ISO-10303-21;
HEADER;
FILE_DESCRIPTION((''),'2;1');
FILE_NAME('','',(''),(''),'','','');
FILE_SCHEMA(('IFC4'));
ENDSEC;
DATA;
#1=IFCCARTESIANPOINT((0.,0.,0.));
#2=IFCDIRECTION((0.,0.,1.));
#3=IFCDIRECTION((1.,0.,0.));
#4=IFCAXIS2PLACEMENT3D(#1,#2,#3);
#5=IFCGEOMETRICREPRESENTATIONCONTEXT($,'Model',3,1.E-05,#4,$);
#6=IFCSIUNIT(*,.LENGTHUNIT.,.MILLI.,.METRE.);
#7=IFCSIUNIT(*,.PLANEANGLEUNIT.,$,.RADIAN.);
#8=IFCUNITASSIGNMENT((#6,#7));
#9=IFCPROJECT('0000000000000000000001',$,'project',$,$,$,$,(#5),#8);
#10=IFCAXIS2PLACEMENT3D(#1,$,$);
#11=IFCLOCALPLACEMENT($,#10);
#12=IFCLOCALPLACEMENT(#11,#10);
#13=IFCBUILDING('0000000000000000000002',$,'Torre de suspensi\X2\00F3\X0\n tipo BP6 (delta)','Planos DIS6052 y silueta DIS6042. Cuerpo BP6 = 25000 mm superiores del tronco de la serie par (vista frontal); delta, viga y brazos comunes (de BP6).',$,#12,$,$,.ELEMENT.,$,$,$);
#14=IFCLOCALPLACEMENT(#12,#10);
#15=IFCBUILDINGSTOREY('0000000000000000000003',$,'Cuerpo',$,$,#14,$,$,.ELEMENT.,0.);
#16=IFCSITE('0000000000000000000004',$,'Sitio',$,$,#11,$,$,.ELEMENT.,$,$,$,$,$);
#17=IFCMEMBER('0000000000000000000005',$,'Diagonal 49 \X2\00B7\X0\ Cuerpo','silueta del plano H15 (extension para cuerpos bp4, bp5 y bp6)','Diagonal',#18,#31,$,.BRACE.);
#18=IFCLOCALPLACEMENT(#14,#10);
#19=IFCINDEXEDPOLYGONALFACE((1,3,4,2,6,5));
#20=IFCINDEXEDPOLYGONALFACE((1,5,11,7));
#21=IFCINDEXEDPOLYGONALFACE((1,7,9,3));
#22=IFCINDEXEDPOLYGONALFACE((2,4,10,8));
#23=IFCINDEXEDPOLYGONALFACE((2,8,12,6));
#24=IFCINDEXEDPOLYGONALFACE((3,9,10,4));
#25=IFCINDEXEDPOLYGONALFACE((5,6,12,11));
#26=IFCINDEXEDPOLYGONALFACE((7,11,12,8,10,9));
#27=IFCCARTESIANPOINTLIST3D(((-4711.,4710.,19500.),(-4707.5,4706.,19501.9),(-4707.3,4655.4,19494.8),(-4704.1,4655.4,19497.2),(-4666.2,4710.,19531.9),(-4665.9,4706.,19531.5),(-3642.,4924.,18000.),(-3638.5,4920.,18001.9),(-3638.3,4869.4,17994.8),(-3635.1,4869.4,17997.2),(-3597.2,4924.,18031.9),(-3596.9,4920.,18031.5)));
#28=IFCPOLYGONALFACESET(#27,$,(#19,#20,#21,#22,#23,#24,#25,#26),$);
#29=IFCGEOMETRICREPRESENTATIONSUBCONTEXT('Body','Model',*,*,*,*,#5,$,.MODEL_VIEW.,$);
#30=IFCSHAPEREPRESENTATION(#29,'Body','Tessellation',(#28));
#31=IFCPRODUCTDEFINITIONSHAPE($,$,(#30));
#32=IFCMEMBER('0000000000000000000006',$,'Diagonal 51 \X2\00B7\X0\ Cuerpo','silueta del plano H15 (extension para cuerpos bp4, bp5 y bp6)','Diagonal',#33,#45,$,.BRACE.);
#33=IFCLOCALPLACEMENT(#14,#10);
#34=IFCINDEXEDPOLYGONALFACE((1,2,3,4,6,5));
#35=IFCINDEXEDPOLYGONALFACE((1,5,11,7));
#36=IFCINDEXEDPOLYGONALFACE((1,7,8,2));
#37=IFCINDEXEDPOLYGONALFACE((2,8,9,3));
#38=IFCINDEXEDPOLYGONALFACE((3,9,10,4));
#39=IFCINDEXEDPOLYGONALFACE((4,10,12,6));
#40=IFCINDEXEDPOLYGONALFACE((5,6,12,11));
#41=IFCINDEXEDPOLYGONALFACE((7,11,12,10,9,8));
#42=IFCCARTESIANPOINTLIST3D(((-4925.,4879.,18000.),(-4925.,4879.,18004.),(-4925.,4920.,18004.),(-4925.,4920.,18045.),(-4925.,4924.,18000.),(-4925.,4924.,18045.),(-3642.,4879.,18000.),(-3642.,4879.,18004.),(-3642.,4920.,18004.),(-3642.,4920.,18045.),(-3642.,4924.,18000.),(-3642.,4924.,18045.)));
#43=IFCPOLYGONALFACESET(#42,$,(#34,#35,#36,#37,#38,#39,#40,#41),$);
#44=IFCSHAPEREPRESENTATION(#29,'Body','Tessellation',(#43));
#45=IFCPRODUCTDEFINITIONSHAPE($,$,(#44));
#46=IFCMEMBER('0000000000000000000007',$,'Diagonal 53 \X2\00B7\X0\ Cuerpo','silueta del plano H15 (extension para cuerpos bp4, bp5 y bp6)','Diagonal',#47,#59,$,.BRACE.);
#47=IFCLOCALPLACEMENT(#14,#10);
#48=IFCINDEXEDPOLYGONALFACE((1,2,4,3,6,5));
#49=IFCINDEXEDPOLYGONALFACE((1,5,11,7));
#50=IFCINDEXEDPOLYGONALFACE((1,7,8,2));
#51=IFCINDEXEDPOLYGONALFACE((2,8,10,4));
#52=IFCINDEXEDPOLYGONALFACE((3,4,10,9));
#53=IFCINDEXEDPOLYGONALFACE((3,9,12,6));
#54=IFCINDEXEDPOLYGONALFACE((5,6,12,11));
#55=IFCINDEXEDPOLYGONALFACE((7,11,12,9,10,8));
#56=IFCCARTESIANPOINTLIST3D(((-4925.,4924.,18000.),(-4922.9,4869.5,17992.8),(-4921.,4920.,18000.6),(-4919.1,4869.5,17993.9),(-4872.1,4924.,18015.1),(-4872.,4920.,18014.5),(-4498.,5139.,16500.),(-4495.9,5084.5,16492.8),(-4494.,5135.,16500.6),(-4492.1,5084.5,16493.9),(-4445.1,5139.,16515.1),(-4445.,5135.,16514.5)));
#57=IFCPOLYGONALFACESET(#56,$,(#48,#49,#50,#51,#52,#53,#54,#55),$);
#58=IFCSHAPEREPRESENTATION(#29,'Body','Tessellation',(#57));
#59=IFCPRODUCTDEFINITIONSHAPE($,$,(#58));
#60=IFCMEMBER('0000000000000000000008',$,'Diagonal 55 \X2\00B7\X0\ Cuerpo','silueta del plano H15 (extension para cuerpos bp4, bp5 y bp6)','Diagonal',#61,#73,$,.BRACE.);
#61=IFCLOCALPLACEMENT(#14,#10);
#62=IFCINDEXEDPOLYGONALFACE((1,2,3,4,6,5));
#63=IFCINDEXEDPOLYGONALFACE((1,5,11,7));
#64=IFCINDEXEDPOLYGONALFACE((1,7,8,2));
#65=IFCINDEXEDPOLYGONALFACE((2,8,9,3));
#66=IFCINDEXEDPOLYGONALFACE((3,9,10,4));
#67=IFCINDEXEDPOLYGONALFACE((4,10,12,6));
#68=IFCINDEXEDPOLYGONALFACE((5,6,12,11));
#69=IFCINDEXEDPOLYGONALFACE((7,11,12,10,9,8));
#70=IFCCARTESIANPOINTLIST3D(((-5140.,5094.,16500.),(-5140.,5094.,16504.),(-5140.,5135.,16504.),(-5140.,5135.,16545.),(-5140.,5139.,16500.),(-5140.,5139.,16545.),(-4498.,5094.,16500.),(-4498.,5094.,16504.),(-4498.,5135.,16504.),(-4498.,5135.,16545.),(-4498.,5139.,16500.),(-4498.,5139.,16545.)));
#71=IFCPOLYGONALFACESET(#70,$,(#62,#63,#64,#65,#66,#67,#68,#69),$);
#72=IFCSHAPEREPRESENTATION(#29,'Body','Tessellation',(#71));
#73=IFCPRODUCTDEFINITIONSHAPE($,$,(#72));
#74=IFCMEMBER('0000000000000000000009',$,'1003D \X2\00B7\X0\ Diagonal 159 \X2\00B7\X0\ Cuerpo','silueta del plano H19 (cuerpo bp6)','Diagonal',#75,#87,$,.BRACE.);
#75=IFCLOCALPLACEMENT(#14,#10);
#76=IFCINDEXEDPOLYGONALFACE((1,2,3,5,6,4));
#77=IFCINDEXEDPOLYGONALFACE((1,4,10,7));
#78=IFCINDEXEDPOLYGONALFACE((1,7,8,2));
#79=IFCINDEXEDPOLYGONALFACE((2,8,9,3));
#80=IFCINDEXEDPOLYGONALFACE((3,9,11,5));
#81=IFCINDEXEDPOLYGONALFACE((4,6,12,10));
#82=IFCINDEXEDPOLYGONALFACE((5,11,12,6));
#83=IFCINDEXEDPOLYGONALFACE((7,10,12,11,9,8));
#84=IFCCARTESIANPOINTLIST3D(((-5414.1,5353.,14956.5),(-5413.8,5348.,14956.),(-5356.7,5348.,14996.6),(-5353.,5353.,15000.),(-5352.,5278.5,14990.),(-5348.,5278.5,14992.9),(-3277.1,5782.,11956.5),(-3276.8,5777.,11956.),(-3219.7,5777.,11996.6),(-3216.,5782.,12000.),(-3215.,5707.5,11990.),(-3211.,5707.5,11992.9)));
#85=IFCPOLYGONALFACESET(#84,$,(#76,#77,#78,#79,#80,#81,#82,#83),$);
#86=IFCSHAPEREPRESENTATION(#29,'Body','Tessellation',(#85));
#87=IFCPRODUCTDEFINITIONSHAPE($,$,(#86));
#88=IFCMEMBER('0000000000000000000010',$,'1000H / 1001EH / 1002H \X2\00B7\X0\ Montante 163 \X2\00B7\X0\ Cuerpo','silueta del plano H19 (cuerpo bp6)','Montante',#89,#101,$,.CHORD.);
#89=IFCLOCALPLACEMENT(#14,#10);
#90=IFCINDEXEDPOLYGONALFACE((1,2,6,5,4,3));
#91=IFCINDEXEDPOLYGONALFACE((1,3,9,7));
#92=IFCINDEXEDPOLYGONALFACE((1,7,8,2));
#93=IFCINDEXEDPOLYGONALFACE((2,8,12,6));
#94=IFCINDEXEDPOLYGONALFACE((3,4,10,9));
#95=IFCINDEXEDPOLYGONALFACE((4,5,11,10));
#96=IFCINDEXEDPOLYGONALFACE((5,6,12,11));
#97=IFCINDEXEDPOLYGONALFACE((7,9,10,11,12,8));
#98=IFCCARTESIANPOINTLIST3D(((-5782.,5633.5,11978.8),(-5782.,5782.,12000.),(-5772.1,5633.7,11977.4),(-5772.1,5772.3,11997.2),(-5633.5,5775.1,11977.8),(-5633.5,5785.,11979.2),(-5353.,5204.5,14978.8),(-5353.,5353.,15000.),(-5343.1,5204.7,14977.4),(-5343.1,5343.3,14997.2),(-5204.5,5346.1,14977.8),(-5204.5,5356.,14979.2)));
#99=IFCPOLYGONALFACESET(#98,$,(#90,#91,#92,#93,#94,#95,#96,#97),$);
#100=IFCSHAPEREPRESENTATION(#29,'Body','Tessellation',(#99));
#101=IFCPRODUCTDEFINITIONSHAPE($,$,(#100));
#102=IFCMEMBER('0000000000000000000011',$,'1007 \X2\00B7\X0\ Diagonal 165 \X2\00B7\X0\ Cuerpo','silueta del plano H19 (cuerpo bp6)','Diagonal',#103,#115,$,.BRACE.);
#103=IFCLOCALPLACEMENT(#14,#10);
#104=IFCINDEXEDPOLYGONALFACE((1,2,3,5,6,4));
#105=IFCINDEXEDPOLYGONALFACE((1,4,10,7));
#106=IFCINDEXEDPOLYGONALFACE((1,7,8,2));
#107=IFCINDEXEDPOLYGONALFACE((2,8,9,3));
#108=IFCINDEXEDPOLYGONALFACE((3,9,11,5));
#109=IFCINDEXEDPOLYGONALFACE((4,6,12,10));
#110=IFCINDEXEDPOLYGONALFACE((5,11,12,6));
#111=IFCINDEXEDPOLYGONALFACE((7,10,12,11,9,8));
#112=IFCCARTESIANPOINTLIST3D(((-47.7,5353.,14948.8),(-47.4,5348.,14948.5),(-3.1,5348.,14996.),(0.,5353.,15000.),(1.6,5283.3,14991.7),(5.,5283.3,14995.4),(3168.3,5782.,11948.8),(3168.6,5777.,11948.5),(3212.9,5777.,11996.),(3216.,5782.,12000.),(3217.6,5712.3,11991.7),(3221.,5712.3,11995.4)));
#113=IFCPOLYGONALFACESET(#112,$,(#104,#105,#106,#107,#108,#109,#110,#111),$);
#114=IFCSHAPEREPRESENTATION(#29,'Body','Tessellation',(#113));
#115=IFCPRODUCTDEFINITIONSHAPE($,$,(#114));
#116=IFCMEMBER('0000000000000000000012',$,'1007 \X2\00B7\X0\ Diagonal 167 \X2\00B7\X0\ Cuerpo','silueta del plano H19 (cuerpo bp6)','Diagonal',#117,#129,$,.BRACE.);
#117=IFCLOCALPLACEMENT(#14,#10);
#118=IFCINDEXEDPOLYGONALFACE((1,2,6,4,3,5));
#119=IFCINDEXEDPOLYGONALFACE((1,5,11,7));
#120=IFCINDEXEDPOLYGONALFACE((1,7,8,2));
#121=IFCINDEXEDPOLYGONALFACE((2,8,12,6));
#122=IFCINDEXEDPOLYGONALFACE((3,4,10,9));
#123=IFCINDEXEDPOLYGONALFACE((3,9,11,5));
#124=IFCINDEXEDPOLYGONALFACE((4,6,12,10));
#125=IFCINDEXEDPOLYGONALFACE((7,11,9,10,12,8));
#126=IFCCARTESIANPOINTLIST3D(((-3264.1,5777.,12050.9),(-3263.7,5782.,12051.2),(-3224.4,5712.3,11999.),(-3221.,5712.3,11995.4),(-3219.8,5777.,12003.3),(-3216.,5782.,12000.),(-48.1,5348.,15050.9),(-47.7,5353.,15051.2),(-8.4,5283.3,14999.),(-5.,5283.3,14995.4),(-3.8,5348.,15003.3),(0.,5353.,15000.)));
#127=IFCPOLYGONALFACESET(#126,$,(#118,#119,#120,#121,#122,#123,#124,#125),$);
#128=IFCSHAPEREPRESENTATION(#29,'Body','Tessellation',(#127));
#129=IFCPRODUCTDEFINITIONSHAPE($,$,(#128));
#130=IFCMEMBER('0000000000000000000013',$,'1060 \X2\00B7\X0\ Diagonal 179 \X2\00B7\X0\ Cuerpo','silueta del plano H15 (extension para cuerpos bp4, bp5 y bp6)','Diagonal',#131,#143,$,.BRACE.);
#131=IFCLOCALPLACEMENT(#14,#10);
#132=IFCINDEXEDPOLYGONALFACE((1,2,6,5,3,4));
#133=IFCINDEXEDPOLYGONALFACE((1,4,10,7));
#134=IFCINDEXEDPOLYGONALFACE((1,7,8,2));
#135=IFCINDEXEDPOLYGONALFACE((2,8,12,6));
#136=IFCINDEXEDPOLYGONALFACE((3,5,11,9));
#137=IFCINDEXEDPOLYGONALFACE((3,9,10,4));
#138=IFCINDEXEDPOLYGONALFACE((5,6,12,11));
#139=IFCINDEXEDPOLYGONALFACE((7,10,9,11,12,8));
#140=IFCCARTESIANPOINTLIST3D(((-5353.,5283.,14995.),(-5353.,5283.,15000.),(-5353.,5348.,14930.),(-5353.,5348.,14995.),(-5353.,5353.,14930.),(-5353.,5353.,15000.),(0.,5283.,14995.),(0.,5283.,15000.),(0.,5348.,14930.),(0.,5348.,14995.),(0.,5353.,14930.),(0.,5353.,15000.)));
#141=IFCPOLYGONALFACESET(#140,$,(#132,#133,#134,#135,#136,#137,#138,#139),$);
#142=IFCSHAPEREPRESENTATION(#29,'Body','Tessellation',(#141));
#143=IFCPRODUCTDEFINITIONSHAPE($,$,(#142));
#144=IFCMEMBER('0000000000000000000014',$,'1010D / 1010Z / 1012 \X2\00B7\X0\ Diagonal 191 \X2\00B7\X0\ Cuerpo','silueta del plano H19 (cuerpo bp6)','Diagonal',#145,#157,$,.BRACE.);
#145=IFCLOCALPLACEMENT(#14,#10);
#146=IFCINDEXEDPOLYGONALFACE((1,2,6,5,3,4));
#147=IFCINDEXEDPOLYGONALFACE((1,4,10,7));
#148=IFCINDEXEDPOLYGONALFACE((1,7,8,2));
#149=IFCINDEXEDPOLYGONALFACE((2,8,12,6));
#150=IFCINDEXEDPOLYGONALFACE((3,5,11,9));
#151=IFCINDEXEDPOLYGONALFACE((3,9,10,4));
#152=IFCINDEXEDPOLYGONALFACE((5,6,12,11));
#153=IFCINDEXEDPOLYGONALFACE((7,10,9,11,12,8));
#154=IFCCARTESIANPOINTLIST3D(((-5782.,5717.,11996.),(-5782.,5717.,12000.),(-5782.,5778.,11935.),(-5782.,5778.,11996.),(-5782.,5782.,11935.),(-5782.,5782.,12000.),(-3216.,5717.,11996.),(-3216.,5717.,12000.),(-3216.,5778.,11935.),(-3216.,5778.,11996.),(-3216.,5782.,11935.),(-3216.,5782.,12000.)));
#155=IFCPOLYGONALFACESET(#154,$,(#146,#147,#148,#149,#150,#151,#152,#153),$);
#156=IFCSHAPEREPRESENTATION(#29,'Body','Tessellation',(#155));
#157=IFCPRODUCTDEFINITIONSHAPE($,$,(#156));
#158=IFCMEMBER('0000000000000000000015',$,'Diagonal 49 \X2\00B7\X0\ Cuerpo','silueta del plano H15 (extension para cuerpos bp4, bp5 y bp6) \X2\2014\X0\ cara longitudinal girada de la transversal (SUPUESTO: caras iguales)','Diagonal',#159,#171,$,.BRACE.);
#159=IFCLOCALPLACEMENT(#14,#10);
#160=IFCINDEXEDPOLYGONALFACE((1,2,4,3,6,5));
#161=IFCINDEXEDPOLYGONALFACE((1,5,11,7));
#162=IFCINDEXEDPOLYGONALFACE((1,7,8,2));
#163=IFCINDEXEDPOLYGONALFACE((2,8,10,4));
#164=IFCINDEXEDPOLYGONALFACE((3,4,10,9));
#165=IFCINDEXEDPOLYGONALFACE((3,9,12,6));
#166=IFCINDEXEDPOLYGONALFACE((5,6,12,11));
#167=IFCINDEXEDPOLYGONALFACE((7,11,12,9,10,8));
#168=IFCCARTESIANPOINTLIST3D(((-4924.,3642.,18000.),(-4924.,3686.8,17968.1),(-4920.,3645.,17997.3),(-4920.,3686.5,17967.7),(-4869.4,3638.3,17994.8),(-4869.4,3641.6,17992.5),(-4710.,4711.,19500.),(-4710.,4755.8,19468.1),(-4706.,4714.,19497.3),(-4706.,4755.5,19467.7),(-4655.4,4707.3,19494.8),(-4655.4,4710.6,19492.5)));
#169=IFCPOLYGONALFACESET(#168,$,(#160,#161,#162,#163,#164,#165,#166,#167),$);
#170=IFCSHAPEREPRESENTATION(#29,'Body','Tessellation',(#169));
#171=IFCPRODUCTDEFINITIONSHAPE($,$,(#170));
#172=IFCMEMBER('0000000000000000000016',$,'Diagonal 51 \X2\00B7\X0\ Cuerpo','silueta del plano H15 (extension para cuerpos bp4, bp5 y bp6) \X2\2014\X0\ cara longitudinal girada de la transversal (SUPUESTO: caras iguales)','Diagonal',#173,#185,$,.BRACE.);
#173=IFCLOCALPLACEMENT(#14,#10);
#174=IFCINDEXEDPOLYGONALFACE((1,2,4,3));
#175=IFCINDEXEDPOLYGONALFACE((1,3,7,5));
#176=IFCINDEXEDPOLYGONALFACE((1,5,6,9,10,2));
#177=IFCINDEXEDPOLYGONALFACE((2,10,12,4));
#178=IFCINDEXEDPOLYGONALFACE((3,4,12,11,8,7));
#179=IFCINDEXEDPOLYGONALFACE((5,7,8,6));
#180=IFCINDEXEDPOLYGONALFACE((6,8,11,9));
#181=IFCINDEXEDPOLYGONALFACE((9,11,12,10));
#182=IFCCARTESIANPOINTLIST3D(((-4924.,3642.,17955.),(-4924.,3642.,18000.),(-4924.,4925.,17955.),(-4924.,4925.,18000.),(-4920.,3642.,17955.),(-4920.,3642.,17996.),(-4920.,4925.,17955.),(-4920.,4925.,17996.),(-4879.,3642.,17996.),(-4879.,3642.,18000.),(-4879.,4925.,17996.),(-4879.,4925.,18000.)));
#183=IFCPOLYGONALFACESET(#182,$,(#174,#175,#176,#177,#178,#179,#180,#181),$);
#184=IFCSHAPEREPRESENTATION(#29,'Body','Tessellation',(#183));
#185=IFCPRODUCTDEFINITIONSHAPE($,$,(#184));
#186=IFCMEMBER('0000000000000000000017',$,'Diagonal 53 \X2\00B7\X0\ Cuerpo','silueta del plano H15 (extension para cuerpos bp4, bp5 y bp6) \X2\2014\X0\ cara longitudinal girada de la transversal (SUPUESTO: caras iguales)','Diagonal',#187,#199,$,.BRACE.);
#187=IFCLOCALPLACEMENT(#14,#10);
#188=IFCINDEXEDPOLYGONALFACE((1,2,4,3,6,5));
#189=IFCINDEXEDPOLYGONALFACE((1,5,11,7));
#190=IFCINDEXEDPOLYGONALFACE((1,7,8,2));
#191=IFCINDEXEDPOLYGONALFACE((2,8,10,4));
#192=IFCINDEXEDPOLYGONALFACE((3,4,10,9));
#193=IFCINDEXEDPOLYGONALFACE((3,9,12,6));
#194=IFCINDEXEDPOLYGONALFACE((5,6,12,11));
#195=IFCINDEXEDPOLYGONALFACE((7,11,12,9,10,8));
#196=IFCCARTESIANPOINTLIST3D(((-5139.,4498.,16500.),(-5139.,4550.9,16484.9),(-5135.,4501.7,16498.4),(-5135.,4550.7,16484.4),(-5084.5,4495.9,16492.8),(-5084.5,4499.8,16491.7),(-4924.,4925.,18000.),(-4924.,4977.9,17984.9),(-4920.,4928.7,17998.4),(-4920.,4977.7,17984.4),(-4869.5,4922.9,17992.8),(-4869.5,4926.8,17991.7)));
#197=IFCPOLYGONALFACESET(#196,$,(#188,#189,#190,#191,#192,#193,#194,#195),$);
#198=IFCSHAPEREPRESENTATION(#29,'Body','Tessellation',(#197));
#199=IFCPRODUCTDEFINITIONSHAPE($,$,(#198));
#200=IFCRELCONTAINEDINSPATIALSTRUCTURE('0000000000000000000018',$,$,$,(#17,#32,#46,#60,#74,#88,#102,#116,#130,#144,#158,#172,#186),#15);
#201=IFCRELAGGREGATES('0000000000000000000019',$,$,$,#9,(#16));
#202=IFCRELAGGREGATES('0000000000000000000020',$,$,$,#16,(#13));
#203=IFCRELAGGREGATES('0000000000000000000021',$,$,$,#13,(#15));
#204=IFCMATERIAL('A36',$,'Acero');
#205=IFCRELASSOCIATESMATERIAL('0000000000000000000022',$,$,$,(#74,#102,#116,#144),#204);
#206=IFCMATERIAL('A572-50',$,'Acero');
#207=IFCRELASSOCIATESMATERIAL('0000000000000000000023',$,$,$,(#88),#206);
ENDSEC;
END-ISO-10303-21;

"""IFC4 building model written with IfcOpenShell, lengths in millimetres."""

from ifc_helpers import new_model, si_unit, frame, frame_2d, origin, origin_with_axes, place, context, subcontext, project, spatial, l_section, extrude, material, element, save


model = new_model("IFC4")

# Units and contexts
model_context = context("Model", 3, precision=1e-05, world=origin_with_axes())
body_context = subcontext(model_context, "Body", "Model", "MODEL_VIEW")
ifc_project = project(units=[si_unit("LENGTHUNIT", "METRE", prefix="MILLI"), si_unit("PLANEANGLEUNIT", "RADIAN")], contexts=[model_context])

# Site, building, storey
site_placement = place(None, origin())
site = spatial("IfcSite", under=ifc_project, at=site_placement, Name="Sitio", CompositionType="ELEMENT")
building_placement = place(site_placement, origin())
building = spatial("IfcBuilding", under=site, at=building_placement, Name="Torre de suspensión tipo BP6 (delta)", Description="Planos DIS6052 y silueta DIS6042. Cuerpo BP6 = 25000 mm superiores del tronco de la serie par (vista frontal); delta, viga y brazos comunes (de BP6).", CompositionType="ELEMENT")
storey_placement = place(building_placement, origin())
storey = spatial("IfcBuildingStorey", under=building, at=storey_placement, Name="Cuerpo", CompositionType="ELEMENT", Elevation=0.0)

# Members
member_1_placement = place(storey_placement, frame((-3642.0, 4924.0, 18000.0), z_axis=(-0.576487, -0.115405, 0.808915), x_axis=(0.066977, -0.993318, -0.093981)))
element("IfcMember", 1, at=member_1_placement, inside=storey, Name="Diagonal 49 · Cuerpo", Description="silueta del plano H15 (extension para cuerpos bp4, bp5 y bp6)", ObjectType="Diagonal", PredefinedType="BRACE", context=body_context, shape_type="SweptSolid", body=[
    extrude(l_section(Depth=55.0, Width=55.0, Thickness=4.0, at=frame_2d((27.5, 27.5))), None, (0.0, 0.0, 1.0), 1854.3),
])
member_2_placement = place(storey_placement, frame((-3642.0, 4924.0, 18000.0), z_axis=(-1.0, 0.0, 0.0), x_axis=(0.0, -1.0, 0.0)))
element("IfcMember", 2, at=member_2_placement, inside=storey, Name="Diagonal 51 · Cuerpo", Description="silueta del plano H15 (extension para cuerpos bp4, bp5 y bp6)", ObjectType="Diagonal", PredefinedType="BRACE", context=body_context, shape_type="SweptSolid", body=[
    extrude(l_section(Depth=45.0, Width=45.0, Thickness=4.0, at=frame_2d((22.5, 22.5))), None, (0.0, 0.0, 1.0), 1283.0),
])
member_3_placement = place(storey_placement, frame((-4498.0, 5139.0, 16500.0), z_axis=(-0.271224, -0.136565, 0.952779), x_axis=(0.03739, -0.990631, -0.131347)))
element("IfcMember", 3, at=member_3_placement, inside=storey, Name="Diagonal 53 · Cuerpo", Description="silueta del plano H15 (extension para cuerpos bp4, bp5 y bp6)", ObjectType="Diagonal", PredefinedType="BRACE", context=body_context, shape_type="SweptSolid", body=[
    extrude(l_section(Depth=55.0, Width=55.0, Thickness=4.0, at=frame_2d((27.5, 27.5))), None, (0.0, 0.0, 1.0), 1574.3),
])
member_4_placement = place(storey_placement, frame((-4498.0, 5139.0, 16500.0), z_axis=(-1.0, 0.0, 0.0), x_axis=(0.0, -1.0, 0.0)))
element("IfcMember", 4, at=member_4_placement, inside=storey, Name="Diagonal 55 · Cuerpo", Description="silueta del plano H15 (extension para cuerpos bp4, bp5 y bp6)", ObjectType="Diagonal", PredefinedType="BRACE", context=body_context, shape_type="SweptSolid", body=[
    extrude(l_section(Depth=45.0, Width=45.0, Thickness=4.0, at=frame_2d((22.5, 22.5))), None, (0.0, 0.0, 1.0), 642.0),
])
ifc_material_1 = material(Name="A36", Category="Acero")
member_5_placement = place(storey_placement, frame((-5353.0, 5353.0, 15000.0), z_axis=(0.576289, 0.115689, -0.809016), x_axis=(0.067121, -0.993285, -0.094227)))
element("IfcMember", 5, at=member_5_placement, inside=storey, material=ifc_material_1, Name="1003D · Diagonal 159 · Cuerpo", Description="silueta del plano H19 (cuerpo bp6)", ObjectType="Diagonal", PredefinedType="BRACE", context=body_context, shape_type="SweptSolid", body=[
    extrude(l_section(Depth=75.0, Width=75.0, Thickness=5.0, at=frame_2d((37.5, 37.5))), None, (0.0, 0.0, 1.0), 3708.2),
])
ifc_material_2 = material(Name="A572-50", Category="Acero")
member_6_placement = place(storey_placement, frame((-5353.0, 5353.0, 15000.0), z_axis=(-0.140163, 0.140163, -0.980158), x_axis=(0.990129, 0.019841, -0.138751)))
element("IfcMember", 6, at=member_6_placement, inside=storey, material=ifc_material_2, Name="1000H / 1001EH / 1002H · Montante 163 · Cuerpo", Description="silueta del plano H19 (cuerpo bp6)", ObjectType="Montante", PredefinedType="CHORD", context=body_context, shape_type="SweptSolid", body=[
    extrude(l_section(Depth=150.0, Width=150.0, Thickness=10.0, at=frame_2d((75.0, 75.0))), None, (0.0, 0.0, 1.0), 3060.7),
])
for number, where, z_axis, x_axis, name in (
    (7, (0.0, 5353.0, 15000.0), (0.727783, 0.097083, -0.678902), (0.070991, -0.995276, -0.066223), "1007 · Diagonal 165 · Cuerpo"),
    (8, (0.0, 5353.0, 15000.0), (-0.727783, 0.097083, -0.678902), (-0.070991, -0.995276, -0.066223), "1007 · Diagonal 167 · Cuerpo"),
):
    element("IfcMember", number, at=place(storey_placement, frame(where, z_axis=z_axis, x_axis=x_axis)), inside=storey, material=ifc_material_1, Name=name, Description="silueta del plano H19 (cuerpo bp6)", ObjectType="Diagonal", PredefinedType="BRACE", context=body_context, shape_type="SweptSolid", body=[
        extrude(l_section(Depth=70.0, Width=70.0, Thickness=5.0, at=frame_2d((35.0, 35.0))), None, (0.0, 0.0, 1.0), 4418.9),
    ])
member_7_placement = place(storey_placement, frame((-5353.0, 5353.0, 15000.0), z_axis=(1.0, 0.0, 0.0), x_axis=(0.0, -1.0, 0.0)))
element("IfcMember", 9, at=member_7_placement, inside=storey, Name="1060 · Diagonal 179 · Cuerpo", Description="silueta del plano H15 (extension para cuerpos bp4, bp5 y bp6)", ObjectType="Diagonal", PredefinedType="BRACE", context=body_context, shape_type="SweptSolid", body=[
    extrude(l_section(Depth=70.0, Width=70.0, Thickness=5.0, at=frame_2d((35.0, 35.0))), None, (0.0, 0.0, 1.0), 5353.0),
])
member_8_placement = place(storey_placement, frame((-5782.0, 5782.0, 12000.0), z_axis=(1.0, 0.0, 0.0), x_axis=(0.0, -1.0, 0.0)))
element("IfcMember", 10, at=member_8_placement, inside=storey, material=ifc_material_1, Name="1010D / 1010Z / 1012 · Diagonal 191 · Cuerpo", Description="silueta del plano H19 (cuerpo bp6)", ObjectType="Diagonal", PredefinedType="BRACE", context=body_context, shape_type="SweptSolid", body=[
    extrude(l_section(Depth=65.0, Width=65.0, Thickness=4.0, at=frame_2d((32.5, 32.5))), None, (0.0, 0.0, 1.0), 2566.0),
])
member_9_placement = place(storey_placement, frame((-4924.0, 3642.0, 18000.0), z_axis=(0.115405, 0.576487, 0.808915), x_axis=(0.993318, -0.066977, -0.093981)))
element("IfcMember", 11, at=member_9_placement, inside=storey, Name="Diagonal 49 · Cuerpo", Description="silueta del plano H15 (extension para cuerpos bp4, bp5 y bp6) — cara longitudinal girada de la transversal (SUPUESTO: caras iguales)", ObjectType="Diagonal", PredefinedType="BRACE", context=body_context, shape_type="SweptSolid", body=[
    extrude(l_section(Depth=55.0, Width=55.0, Thickness=4.0, at=frame_2d((27.5, 27.5))), None, (0.0, 0.0, 1.0), 1854.3),
])
member_10_placement = place(storey_placement, frame((-4924.0, 3642.0, 18000.0), z_axis=(0.0, 1.0, 0.0), x_axis=(1.0, 0.0, 0.0)))
element("IfcMember", 12, at=member_10_placement, inside=storey, Name="Diagonal 51 · Cuerpo", Description="silueta del plano H15 (extension para cuerpos bp4, bp5 y bp6) — cara longitudinal girada de la transversal (SUPUESTO: caras iguales)", ObjectType="Diagonal", PredefinedType="BRACE", context=body_context, shape_type="SweptSolid", body=[
    extrude(l_section(Depth=45.0, Width=45.0, Thickness=4.0, at=frame_2d((22.5, 22.5))), None, (0.0, 0.0, 1.0), 1283.0),
])
member_11_placement = place(storey_placement, frame((-5139.0, 4498.0, 16500.0), z_axis=(0.136565, 0.271224, 0.952779), x_axis=(0.990631, -0.03739, -0.131347)))
element("IfcMember", 13, at=member_11_placement, inside=storey, Name="Diagonal 53 · Cuerpo", Description="silueta del plano H15 (extension para cuerpos bp4, bp5 y bp6) — cara longitudinal girada de la transversal (SUPUESTO: caras iguales)", ObjectType="Diagonal", PredefinedType="BRACE", context=body_context, shape_type="SweptSolid", body=[
    extrude(l_section(Depth=55.0, Width=55.0, Thickness=4.0, at=frame_2d((27.5, 27.5))), None, (0.0, 0.0, 1.0), 1574.3),
])

save(model, "model.ifc")
